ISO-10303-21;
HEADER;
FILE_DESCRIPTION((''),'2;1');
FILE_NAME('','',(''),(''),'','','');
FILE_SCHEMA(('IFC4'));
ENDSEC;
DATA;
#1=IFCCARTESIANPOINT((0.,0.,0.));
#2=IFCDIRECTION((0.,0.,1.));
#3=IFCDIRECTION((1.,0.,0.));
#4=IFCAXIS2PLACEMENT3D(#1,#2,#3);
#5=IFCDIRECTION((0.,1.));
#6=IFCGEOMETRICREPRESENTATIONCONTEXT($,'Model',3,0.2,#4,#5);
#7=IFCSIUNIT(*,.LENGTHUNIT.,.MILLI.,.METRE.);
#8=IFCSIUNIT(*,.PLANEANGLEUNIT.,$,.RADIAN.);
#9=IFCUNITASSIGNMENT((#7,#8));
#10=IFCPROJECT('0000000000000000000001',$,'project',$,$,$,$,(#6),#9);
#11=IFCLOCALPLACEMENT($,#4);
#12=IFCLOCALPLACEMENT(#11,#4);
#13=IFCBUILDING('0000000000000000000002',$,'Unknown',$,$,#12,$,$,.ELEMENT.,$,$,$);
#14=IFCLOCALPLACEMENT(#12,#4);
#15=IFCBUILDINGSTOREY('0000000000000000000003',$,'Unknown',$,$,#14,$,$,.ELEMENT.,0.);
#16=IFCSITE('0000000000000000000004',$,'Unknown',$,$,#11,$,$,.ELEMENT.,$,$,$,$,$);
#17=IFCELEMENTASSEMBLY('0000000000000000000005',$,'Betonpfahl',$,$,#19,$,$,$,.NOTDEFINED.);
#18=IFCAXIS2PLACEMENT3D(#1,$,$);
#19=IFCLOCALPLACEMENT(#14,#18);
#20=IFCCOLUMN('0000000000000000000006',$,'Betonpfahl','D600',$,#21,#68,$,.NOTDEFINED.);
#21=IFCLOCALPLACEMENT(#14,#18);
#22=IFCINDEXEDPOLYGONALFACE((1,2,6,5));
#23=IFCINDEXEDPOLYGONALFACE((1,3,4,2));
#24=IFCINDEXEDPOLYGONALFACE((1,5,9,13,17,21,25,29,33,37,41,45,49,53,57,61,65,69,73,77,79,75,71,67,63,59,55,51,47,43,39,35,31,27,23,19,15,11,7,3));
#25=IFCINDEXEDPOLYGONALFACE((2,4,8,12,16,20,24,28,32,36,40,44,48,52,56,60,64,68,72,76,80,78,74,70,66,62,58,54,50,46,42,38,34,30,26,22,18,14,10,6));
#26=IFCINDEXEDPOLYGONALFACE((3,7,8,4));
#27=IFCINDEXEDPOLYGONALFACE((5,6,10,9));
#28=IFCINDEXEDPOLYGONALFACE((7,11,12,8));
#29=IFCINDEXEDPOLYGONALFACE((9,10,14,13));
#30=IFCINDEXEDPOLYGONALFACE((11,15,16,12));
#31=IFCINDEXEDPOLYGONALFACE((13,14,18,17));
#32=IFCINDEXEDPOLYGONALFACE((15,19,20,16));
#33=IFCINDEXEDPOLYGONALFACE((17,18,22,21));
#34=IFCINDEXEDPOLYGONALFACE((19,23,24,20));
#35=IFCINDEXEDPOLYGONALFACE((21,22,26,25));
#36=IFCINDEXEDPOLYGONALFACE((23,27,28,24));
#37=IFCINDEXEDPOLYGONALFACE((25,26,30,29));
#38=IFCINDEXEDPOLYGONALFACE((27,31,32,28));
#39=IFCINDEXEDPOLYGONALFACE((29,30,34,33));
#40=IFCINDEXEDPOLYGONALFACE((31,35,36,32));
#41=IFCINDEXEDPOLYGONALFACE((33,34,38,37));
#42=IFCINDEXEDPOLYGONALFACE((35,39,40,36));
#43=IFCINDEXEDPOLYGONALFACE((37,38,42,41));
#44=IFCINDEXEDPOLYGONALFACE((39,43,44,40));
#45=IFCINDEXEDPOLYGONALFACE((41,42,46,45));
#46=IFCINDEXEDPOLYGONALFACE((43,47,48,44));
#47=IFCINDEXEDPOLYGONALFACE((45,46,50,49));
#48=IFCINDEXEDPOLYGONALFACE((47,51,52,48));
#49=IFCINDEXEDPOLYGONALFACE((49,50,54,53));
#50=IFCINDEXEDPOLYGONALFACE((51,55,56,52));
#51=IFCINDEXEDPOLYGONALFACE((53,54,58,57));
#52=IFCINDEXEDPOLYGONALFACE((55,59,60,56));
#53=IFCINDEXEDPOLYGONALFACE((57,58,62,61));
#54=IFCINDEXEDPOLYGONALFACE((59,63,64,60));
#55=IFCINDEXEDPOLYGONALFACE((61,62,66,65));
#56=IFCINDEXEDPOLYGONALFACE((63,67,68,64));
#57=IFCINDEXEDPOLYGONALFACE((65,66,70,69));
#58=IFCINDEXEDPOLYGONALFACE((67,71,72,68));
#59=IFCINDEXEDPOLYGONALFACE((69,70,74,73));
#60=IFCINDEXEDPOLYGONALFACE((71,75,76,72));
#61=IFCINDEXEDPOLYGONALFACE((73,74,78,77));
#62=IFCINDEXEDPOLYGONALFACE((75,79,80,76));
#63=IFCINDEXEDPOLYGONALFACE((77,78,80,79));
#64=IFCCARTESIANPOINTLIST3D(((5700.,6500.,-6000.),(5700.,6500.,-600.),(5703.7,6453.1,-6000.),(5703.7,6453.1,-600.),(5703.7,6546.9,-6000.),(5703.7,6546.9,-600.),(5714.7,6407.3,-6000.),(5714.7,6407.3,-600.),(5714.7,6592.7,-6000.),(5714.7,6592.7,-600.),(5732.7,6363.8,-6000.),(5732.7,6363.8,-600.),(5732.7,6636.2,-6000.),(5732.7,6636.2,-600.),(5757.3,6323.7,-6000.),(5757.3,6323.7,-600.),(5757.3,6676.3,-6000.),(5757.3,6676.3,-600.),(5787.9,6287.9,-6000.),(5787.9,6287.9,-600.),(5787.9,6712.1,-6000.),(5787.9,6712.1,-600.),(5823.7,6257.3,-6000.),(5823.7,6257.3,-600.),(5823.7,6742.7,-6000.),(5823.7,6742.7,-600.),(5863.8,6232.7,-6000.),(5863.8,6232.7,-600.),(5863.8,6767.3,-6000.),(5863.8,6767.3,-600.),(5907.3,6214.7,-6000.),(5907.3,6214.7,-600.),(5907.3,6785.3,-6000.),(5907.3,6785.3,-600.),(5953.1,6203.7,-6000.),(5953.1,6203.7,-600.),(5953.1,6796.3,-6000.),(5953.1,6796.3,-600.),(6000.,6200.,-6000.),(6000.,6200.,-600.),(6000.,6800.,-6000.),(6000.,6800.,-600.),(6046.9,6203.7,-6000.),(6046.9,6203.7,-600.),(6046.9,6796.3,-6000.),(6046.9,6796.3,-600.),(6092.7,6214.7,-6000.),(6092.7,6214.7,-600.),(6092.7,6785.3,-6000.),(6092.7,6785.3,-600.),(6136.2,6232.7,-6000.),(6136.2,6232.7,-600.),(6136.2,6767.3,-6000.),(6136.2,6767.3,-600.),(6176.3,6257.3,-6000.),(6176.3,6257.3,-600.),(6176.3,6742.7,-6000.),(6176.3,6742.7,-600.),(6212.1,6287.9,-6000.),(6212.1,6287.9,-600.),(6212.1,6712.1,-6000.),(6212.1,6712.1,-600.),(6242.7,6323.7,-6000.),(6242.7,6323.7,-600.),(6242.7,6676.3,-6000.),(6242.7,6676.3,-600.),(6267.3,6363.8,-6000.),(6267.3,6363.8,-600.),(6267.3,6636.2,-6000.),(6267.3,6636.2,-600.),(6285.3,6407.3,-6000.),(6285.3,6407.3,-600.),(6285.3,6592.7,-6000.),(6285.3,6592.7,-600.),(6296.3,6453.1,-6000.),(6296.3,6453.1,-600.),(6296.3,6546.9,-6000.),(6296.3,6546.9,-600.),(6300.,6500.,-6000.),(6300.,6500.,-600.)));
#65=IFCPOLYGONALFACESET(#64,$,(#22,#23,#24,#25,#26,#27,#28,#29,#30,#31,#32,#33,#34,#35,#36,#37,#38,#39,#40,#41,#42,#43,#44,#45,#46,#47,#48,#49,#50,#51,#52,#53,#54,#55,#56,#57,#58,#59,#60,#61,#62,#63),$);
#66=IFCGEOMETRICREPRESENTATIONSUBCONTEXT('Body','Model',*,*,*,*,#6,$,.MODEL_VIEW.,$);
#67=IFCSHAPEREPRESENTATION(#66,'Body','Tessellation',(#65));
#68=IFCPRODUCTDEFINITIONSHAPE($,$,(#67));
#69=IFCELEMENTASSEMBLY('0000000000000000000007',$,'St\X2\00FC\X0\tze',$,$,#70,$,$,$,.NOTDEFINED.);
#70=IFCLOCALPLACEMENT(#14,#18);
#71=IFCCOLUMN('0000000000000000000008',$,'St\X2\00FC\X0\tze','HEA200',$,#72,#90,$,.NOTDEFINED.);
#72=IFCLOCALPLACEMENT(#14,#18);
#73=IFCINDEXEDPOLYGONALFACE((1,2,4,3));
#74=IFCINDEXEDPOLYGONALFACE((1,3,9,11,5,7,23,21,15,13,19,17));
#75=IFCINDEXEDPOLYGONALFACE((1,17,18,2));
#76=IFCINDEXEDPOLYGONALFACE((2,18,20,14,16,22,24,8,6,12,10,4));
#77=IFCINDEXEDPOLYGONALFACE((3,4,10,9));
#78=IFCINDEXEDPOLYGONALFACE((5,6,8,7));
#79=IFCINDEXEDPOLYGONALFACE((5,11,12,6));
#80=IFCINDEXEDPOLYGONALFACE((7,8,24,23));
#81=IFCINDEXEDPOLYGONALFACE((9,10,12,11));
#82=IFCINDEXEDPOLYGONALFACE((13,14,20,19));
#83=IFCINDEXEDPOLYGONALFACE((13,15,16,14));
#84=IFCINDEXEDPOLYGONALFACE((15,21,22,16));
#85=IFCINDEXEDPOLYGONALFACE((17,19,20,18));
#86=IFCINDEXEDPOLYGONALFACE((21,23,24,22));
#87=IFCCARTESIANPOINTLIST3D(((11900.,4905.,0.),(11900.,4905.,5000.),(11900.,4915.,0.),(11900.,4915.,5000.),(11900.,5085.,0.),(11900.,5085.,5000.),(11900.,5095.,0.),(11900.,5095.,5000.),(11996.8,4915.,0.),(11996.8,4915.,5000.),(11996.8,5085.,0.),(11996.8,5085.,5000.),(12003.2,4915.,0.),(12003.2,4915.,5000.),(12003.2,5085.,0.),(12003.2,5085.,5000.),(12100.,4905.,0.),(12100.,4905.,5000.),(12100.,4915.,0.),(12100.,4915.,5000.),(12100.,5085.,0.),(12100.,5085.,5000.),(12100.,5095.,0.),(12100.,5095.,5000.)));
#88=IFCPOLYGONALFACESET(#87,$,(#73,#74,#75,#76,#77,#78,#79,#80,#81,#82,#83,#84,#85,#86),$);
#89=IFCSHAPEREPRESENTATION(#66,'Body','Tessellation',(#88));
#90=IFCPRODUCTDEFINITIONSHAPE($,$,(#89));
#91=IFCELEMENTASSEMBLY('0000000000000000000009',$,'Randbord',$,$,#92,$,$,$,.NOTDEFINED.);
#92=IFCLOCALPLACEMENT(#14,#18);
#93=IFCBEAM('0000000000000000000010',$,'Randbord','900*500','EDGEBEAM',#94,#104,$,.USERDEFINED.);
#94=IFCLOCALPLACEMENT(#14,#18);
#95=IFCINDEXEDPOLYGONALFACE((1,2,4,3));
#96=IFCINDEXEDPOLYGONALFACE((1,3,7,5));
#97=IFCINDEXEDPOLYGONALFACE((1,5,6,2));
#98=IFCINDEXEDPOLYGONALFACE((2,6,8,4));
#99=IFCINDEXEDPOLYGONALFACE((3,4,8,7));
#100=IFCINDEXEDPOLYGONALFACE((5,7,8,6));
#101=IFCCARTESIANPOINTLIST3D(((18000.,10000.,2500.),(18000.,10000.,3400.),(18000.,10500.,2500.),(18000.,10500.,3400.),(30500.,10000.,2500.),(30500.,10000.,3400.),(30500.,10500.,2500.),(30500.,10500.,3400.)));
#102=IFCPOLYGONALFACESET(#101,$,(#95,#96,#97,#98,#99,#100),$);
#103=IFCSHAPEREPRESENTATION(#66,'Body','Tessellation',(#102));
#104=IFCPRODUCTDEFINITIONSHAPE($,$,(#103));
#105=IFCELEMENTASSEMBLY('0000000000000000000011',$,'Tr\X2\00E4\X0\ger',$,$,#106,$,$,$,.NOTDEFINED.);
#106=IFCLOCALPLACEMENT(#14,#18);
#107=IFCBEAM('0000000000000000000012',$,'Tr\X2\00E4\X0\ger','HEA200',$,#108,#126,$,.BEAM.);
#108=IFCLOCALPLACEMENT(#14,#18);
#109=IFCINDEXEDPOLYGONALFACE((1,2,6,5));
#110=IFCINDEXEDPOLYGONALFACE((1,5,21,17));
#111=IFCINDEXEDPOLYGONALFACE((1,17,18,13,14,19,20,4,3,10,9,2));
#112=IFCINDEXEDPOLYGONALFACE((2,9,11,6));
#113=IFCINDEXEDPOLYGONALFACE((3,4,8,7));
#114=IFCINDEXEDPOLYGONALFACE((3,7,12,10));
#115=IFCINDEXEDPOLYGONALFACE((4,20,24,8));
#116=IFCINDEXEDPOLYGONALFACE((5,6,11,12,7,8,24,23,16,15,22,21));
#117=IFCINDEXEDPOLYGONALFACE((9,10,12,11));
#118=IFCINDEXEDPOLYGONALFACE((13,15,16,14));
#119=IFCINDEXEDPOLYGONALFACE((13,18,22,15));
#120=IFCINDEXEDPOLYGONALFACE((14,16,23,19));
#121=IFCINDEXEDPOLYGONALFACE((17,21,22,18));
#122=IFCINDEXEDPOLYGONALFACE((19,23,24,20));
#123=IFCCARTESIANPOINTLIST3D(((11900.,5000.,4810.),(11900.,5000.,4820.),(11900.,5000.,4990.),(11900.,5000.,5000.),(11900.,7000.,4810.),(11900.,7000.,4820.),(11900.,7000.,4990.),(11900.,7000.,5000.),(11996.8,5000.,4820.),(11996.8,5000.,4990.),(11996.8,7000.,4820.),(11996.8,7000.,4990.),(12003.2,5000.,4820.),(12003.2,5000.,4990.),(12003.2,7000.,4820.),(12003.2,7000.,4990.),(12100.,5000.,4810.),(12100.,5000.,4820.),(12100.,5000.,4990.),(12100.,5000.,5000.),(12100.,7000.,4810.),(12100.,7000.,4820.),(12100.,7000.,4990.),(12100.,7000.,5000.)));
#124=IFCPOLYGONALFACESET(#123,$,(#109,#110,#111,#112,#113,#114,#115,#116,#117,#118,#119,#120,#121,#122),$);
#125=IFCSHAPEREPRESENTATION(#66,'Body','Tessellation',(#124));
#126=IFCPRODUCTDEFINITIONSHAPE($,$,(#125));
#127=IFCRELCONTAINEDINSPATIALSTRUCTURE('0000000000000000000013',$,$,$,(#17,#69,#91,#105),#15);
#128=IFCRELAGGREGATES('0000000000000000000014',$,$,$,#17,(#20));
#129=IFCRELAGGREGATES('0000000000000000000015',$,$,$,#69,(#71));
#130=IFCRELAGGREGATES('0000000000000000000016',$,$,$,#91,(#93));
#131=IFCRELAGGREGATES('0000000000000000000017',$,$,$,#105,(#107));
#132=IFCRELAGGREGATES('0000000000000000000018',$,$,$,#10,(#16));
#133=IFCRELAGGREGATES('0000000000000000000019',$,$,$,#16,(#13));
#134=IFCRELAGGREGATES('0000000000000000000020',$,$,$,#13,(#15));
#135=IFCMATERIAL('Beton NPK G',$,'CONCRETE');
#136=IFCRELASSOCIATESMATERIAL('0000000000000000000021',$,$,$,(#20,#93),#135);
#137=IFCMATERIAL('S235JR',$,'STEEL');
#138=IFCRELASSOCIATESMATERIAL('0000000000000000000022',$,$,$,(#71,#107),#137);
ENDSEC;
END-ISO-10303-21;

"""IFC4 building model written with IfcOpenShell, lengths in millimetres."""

from ifc_helpers import new_model, si_unit, direction, frame, origin_with_axes, place, context, subcontext, project, spatial, line, indexed_curve, outline, extrude, material, element, aggregate, save


model = new_model("IFC4")

# Units and contexts
model_context = context("Model", 3, precision=0.2, world=origin_with_axes(), true_north=direction((0.0, 1.0)))
body_context = subcontext(model_context, "Body", "Model", "MODEL_VIEW")
ifc_project = project(units=[si_unit("LENGTHUNIT", "METRE", prefix="MILLI"), si_unit("PLANEANGLEUNIT", "RADIAN")], contexts=[model_context])

# Site, building, storey
site_placement = place(None, origin_with_axes())
site = spatial("IfcSite", under=ifc_project, at=site_placement, Name="Unknown", CompositionType="ELEMENT")
building_placement = place(site_placement, origin_with_axes())
building = spatial("IfcBuilding", under=site, at=building_placement, Name="Unknown", CompositionType="ELEMENT")
storey_placement = place(building_placement, origin_with_axes())
storey = spatial("IfcBuildingStorey", under=building, at=storey_placement, Name="Unknown", CompositionType="ELEMENT", Elevation=0.0)

# Element assemblies, columns
assembly_1_placement = place(storey_placement, frame((6000.0, 6500.0, -6000.0), z_axis=(-1.0, 0.0, 0.0), x_axis=(0.0, 0.0, 1.0)))
assembly_1 = element("IfcElementAssembly", 1, at=assembly_1_placement, inside=storey, Name="Betonpfahl", PredefinedType="NOTDEFINED")
ifc_material_1 = material(Name="Beton NPK G", Category="CONCRETE")
column_1_placement = place(assembly_1_placement, origin_with_axes())
column_1 = element("IfcColumn", 2, at=column_1_placement, material=ifc_material_1, Name="Betonpfahl", Description="D600", PredefinedType="NOTDEFINED", context=body_context, shape_type="SolidModel", body=[
    extrude(outline(indexed_curve([(300.0, 0.0), (296.3, 46.9), (285.3, 92.7), (267.3, 136.2), (242.7, 176.3), (212.1, 212.1), (176.3, 242.7), (136.2, 267.3), (92.7, 285.3), (46.9, 296.3), (0.0, 300.0), (-46.9, 296.3), (-92.7, 285.3), (-136.2, 267.3), (-176.3, 242.7), (-212.1, 212.1), (-242.7, 176.3), (-267.3, 136.2), (-285.3, 92.7), (-296.3, 46.9), (-300.0, 0.0), (-296.3, -46.9), (-285.3, -92.7), (-267.3, -136.2), (-242.7, -176.3), (-212.1, -212.1), (-176.3, -242.7), (-136.2, -267.3), (-92.7, -285.3), (-46.9, -296.3), (0.0, -300.0), (46.9, -296.3), (92.7, -285.3), (136.2, -267.3), (176.3, -242.7), (212.1, -212.1), (242.7, -176.3), (267.3, -136.2), (285.3, -92.7), (296.3, -46.9)], segments=[line(1, 2, 3, 4, 5, 6, 7, 8, 9, 10, 11, 12, 13, 14, 15, 16, 17, 18, 19, 20, 21, 22, 23, 24, 25, 26, 27, 28, 29, 30, 31, 32, 33, 34, 35, 36, 37, 38, 39, 40, 1)])), frame((0.0, 0.0, 0.0), z_axis=(-1.0, 0.0, 0.0), x_axis=(0.0, 0.0, 1.0)), (0.0, 0.0, -1.0), 5400.0),
])
aggregate(assembly_1, [column_1])
assembly_2_placement = place(storey_placement, frame((12000.0, 5000.0, 0.0), z_axis=(-1.0, 0.0, 0.0), x_axis=(0.0, 0.0, 1.0)))
assembly_2 = element("IfcElementAssembly", 3, at=assembly_2_placement, inside=storey, Name="Stütze", PredefinedType="NOTDEFINED")
ifc_material_2 = material(Name="S235JR", Category="STEEL")
column_2_placement = place(assembly_2_placement, origin_with_axes())
column_2 = element("IfcColumn", 4, at=column_2_placement, material=ifc_material_2, Name="Stütze", Description="HEA200", PredefinedType="NOTDEFINED", context=body_context, shape_type="SolidModel", body=[
    extrude(outline(indexed_curve([(-100.0, -95.0), (100.0, -95.0), (100.0, -85.0), (3.2, -85.0), (3.2, 85.0), (100.0, 85.0), (100.0, 95.0), (-100.0, 95.0), (-100.0, 85.0), (-3.2, 85.0), (-3.2, -85.0), (-100.0, -85.0)], segments=[line(1, 2, 3, 4, 5, 6, 7, 8, 9, 10, 11, 12, 1)])), frame((0.0, 0.0, 0.0), z_axis=(-1.0, 0.0, 0.0), x_axis=(0.0, 0.0, 1.0)), (0.0, 0.0, -1.0), 5000.0),
])
aggregate(assembly_2, [column_2])

# Element assemblies, beams
assembly_3_placement = place(storey_placement, frame((30500.0, 10250.0, 2950.0), z_axis=(0.0, 1.0, 0.0), x_axis=(-1.0, 0.0, 0.0)))
assembly_3 = element("IfcElementAssembly", 5, at=assembly_3_placement, inside=storey, Name="Randbord", PredefinedType="NOTDEFINED")
beam_1_placement = place(assembly_3_placement, origin_with_axes())
beam_1 = element("IfcBeam", 6, at=beam_1_placement, material=ifc_material_1, Name="Randbord", Description="900*500", ObjectType="EDGEBEAM", PredefinedType="USERDEFINED", context=body_context, shape_type="SolidModel", body=[
    extrude(outline(indexed_curve([(-250.0, -450.0), (250.0, -450.0), (250.0, 450.0), (-250.0, 450.0)], segments=[line(1, 2, 3, 4, 1)])), frame((0.0, 0.0, 0.0), z_axis=(-1.0, 0.0, 0.0), x_axis=(0.0, 0.0, 1.0)), (0.0, 0.0, -1.0), 12500.0),
])
aggregate(assembly_3, [beam_1])
assembly_4_placement = place(storey_placement, frame((12000.0, 5000.0, 4905.0), z_axis=(1.0, 0.0, 0.0), x_axis=(0.0, 1.0, 0.0)))
assembly_4 = element("IfcElementAssembly", 7, at=assembly_4_placement, inside=storey, Name="Träger", PredefinedType="NOTDEFINED")
beam_2_placement = place(assembly_4_placement, origin_with_axes())
beam_2 = element("IfcBeam", 8, at=beam_2_placement, material=ifc_material_2, Name="Träger", Description="HEA200", PredefinedType="BEAM", context=body_context, shape_type="SolidModel", body=[
    extrude(outline(indexed_curve([(-100.0, -95.0), (100.0, -95.0), (100.0, -85.0), (3.2, -85.0), (3.2, 85.0), (100.0, 85.0), (100.0, 95.0), (-100.0, 95.0), (-100.0, 85.0), (-3.2, 85.0), (-3.2, -85.0), (-100.0, -85.0)], segments=[line(1, 2, 3, 4, 5, 6, 7, 8, 9, 10, 11, 12, 1)])), frame((0.0, 0.0, 0.0), z_axis=(-1.0, 0.0, 0.0), x_axis=(0.0, 0.0, 1.0)), (0.0, 0.0, -1.0), 2000.0),
])
aggregate(assembly_4, [beam_2])

save(model, "model.ifc")
